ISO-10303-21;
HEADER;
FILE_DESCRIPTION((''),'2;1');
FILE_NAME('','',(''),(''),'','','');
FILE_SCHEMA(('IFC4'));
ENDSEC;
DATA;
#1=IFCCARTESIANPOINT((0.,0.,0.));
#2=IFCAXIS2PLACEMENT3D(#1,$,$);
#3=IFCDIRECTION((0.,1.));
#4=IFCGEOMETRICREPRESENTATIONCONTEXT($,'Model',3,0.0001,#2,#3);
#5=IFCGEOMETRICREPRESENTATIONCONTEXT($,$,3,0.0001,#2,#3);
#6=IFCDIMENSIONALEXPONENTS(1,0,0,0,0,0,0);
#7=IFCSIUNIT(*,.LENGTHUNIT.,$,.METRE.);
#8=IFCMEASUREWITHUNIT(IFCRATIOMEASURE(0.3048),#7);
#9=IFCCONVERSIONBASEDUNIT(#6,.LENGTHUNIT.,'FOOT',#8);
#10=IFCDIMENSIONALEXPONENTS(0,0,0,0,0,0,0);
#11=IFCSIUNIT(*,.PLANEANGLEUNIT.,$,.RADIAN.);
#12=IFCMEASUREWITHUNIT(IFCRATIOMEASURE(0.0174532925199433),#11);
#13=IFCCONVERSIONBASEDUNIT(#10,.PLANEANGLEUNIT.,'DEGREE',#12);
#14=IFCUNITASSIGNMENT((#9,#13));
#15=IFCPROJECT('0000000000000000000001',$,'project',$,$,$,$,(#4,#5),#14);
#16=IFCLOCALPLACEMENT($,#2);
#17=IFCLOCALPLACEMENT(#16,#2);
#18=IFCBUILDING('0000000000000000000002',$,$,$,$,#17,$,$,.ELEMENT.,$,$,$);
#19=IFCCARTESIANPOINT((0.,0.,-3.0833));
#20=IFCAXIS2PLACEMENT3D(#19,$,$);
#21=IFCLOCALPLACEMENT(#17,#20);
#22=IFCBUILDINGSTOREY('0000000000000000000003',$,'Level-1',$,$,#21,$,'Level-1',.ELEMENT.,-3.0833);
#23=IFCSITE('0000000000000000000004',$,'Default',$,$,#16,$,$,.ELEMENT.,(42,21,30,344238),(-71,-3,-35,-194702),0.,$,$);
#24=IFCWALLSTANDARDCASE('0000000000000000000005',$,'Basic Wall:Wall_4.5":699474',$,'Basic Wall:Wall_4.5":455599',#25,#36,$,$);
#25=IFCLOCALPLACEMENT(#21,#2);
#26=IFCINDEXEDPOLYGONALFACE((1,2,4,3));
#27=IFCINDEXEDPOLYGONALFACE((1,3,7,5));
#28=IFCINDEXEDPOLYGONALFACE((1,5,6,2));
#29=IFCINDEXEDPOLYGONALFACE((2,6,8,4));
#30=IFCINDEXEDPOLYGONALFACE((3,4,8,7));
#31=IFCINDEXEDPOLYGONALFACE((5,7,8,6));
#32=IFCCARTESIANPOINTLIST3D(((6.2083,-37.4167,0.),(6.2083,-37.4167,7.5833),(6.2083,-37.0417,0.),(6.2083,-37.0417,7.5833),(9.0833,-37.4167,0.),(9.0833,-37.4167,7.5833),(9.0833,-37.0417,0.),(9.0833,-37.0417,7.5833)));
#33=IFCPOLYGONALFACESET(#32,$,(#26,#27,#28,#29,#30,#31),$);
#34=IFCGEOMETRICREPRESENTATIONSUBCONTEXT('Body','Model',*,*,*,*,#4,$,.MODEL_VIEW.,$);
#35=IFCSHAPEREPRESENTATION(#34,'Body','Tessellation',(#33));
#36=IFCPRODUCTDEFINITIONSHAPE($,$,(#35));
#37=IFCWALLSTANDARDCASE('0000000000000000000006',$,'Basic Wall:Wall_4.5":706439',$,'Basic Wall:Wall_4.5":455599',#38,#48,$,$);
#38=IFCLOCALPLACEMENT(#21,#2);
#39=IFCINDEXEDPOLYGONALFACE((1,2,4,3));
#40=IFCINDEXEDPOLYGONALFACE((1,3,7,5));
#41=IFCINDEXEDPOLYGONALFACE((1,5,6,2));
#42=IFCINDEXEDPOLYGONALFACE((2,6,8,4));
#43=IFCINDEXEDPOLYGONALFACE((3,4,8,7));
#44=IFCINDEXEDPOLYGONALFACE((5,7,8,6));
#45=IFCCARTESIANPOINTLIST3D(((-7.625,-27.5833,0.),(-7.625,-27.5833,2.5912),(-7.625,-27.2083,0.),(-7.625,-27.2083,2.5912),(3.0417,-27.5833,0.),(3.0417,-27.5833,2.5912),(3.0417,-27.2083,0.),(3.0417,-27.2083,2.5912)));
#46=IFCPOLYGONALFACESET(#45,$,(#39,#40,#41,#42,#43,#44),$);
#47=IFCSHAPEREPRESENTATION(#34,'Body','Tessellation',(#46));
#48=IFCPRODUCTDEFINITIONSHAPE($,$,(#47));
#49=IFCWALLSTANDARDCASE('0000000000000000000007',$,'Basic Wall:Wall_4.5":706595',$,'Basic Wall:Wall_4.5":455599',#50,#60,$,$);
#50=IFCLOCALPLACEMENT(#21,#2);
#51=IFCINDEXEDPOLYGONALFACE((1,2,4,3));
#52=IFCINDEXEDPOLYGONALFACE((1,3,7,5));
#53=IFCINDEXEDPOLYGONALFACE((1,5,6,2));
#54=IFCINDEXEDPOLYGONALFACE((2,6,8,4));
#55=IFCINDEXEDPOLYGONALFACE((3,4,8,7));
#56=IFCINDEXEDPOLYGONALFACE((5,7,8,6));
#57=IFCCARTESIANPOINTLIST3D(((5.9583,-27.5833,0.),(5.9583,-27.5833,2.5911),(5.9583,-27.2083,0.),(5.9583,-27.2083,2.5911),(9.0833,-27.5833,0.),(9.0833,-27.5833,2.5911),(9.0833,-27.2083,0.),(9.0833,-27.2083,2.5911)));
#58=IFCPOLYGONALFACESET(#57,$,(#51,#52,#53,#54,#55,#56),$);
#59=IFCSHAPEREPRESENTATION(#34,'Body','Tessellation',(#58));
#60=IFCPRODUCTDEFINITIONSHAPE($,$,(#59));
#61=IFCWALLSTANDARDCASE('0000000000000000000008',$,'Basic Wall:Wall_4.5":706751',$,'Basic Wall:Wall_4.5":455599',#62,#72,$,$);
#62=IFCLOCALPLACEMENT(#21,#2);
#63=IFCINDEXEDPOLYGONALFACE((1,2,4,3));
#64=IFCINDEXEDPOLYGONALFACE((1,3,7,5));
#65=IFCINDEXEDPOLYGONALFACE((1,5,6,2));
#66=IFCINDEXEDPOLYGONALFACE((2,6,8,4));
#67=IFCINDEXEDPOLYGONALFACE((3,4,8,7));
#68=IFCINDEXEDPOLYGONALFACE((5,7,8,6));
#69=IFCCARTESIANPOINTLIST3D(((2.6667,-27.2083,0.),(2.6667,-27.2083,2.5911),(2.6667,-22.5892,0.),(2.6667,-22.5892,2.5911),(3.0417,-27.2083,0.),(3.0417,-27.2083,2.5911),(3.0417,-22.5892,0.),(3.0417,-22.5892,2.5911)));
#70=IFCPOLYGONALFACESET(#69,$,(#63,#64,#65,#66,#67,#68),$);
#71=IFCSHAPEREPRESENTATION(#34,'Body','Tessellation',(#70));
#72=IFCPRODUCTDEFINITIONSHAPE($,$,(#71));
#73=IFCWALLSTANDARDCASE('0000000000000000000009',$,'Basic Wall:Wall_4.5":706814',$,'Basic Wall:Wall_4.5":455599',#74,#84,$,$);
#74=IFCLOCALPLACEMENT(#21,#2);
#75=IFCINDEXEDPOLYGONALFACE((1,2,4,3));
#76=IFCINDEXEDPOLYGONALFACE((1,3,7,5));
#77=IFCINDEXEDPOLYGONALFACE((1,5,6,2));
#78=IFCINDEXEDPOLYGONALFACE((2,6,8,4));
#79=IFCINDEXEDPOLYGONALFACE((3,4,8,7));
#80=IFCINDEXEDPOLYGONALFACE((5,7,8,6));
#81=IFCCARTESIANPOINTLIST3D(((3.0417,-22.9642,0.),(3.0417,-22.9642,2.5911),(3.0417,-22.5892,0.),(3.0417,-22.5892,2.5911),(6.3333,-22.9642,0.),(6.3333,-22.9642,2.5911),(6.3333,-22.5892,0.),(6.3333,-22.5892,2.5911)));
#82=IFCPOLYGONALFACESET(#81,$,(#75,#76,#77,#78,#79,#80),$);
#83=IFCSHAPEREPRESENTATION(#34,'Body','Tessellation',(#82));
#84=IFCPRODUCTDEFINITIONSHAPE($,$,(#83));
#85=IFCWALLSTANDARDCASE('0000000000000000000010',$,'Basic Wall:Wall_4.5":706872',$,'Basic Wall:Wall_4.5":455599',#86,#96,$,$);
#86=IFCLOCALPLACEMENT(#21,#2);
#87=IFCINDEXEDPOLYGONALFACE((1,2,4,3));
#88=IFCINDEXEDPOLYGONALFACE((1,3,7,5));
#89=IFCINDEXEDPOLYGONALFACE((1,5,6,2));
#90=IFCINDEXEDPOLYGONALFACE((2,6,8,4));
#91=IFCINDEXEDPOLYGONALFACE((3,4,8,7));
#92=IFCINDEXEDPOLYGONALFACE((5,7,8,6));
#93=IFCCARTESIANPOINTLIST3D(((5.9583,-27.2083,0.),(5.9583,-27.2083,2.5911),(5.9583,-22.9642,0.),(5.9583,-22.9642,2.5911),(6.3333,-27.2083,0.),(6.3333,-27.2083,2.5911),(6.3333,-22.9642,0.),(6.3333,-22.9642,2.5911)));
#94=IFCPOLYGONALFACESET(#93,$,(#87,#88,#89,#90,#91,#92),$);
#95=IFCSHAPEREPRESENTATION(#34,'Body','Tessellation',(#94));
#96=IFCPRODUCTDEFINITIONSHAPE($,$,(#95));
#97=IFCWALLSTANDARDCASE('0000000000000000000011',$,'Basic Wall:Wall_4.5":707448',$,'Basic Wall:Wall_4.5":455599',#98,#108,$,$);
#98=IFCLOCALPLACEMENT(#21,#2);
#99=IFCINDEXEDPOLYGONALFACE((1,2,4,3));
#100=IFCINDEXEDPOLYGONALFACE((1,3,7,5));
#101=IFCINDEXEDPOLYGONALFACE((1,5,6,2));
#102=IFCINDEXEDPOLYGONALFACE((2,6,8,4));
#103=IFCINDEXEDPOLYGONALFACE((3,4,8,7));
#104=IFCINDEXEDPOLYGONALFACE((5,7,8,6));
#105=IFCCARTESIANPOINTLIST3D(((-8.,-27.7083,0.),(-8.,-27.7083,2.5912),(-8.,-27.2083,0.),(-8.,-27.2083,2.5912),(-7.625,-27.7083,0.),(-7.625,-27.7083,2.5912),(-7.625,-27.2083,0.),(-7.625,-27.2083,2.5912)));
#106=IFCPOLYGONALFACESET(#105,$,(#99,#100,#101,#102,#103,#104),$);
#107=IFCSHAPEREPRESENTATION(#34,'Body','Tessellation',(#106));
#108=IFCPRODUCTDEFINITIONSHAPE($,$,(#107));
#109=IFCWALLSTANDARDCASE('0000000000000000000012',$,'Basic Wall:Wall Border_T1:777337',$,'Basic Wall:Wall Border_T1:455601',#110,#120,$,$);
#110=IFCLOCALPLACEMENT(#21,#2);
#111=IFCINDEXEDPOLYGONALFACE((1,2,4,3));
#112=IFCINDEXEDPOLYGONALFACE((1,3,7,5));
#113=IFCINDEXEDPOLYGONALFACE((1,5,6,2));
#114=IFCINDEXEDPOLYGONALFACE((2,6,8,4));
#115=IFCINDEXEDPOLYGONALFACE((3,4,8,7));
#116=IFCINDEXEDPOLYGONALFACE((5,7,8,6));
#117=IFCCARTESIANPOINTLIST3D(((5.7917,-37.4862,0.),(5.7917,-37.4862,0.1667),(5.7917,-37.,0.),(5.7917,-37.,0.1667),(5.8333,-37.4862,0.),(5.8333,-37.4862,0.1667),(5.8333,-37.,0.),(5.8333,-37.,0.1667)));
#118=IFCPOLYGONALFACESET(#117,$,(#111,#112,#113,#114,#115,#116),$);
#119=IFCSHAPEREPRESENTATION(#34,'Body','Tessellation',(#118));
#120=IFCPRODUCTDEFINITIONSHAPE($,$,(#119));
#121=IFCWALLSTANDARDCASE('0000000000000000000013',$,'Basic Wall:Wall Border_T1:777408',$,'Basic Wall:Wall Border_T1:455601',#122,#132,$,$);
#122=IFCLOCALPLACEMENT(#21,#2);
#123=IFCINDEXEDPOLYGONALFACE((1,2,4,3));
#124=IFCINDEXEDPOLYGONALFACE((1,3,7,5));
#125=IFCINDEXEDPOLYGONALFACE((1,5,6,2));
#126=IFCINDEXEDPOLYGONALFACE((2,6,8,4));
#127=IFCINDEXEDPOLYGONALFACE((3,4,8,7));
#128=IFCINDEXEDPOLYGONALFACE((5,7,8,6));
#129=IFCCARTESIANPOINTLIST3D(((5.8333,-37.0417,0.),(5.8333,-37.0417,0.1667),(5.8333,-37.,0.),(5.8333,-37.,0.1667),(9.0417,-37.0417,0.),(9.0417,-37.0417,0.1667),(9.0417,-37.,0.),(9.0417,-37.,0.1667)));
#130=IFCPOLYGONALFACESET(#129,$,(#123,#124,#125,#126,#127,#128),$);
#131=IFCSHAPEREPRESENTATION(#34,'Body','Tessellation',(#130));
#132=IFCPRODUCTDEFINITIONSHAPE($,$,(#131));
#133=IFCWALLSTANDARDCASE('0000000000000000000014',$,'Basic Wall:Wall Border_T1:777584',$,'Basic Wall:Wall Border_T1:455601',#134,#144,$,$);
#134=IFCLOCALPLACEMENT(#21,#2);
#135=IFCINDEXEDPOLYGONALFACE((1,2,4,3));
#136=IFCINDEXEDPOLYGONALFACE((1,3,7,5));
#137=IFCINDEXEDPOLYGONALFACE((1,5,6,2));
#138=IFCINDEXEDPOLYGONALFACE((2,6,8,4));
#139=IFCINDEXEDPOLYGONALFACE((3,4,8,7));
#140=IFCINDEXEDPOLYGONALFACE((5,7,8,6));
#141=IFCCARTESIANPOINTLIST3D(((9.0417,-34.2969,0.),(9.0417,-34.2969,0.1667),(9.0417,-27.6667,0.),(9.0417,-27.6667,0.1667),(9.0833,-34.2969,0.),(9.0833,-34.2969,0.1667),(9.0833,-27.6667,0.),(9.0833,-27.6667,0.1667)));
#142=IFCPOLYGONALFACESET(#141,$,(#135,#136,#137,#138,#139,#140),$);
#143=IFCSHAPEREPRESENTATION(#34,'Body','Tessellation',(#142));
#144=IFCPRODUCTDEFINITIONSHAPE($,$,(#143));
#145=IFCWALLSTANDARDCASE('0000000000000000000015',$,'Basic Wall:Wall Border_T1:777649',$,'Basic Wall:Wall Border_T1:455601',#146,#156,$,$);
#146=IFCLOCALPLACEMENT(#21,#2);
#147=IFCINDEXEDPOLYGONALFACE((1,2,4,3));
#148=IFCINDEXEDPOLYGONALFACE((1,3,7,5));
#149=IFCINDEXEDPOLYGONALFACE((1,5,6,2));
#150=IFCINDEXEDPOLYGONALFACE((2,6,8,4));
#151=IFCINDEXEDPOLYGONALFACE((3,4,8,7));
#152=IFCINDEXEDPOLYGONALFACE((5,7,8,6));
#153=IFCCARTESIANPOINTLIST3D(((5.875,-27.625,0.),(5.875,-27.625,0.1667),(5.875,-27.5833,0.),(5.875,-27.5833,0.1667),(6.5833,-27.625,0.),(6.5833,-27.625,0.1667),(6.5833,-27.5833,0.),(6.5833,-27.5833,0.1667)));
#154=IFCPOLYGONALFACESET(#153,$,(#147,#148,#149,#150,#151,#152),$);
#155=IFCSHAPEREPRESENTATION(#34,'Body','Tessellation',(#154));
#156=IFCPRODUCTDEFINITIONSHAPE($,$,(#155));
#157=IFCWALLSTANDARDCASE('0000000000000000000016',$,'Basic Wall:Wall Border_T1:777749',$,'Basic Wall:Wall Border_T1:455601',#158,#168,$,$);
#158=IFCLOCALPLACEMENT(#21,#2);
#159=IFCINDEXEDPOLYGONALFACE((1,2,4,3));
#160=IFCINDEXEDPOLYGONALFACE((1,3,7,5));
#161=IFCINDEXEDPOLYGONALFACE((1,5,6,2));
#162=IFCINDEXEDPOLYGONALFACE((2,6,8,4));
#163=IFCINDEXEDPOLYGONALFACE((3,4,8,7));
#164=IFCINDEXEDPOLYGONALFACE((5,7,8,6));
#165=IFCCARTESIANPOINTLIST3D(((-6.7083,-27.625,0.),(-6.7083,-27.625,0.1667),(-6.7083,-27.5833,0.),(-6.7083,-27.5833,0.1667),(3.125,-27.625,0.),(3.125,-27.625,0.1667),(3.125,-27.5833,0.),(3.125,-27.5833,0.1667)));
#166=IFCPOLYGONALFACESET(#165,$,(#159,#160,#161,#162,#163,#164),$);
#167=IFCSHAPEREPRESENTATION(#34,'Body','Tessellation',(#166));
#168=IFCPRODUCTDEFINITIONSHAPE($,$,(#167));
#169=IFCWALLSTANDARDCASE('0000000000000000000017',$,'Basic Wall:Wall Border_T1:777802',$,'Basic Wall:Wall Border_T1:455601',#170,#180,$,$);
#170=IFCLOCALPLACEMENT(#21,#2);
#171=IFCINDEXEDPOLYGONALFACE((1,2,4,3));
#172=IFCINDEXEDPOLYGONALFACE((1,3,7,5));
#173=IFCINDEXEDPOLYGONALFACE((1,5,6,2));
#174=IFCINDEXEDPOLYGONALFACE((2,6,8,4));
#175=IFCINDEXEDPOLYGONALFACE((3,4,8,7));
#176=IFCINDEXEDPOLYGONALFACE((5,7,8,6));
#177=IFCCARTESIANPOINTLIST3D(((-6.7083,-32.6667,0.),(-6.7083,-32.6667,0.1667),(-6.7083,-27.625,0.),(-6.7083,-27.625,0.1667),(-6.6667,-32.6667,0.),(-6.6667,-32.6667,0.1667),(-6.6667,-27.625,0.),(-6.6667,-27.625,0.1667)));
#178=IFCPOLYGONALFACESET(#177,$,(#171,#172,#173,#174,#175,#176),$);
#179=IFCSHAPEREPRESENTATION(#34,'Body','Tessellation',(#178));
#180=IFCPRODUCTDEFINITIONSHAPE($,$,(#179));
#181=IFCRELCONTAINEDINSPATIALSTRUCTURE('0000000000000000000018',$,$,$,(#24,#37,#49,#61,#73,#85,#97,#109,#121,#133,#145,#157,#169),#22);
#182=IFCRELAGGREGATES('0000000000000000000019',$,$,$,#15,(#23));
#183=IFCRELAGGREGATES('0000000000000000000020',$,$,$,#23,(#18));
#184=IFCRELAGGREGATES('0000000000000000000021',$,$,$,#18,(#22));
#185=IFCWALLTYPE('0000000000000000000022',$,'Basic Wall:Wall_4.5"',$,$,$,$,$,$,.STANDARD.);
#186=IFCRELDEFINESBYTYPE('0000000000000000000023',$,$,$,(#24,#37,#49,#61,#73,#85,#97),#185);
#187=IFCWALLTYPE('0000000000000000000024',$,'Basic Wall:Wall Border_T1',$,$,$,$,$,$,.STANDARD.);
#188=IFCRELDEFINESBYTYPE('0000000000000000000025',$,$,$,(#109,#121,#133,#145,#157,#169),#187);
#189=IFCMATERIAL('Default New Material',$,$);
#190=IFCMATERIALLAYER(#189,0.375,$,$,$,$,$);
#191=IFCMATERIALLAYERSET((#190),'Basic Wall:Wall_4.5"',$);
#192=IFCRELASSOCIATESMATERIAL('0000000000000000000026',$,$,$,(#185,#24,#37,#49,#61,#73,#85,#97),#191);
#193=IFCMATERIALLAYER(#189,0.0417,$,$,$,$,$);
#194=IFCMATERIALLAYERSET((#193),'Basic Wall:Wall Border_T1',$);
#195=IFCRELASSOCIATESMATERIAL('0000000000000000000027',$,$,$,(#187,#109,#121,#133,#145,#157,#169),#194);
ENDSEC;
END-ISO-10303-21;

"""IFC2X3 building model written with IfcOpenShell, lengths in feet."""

from ifc_helpers import new_model, entity, si_unit, converted_unit, direction, frame, frame_2d, origin, place, context, subcontext, project, spatial, rectangle, extrude, material, layer, layer_set, layer_usage, type_object, element, save


model = new_model("IFC2X3")

# Units and contexts
model_context = context("Model", 3, precision=0.0001, world=origin(), true_north=direction((0.0, 1.0)))
context_of_model = context(None, 3, precision=0.0001, world=origin(), true_north=direction((0.0, 1.0)))
body_context = subcontext(model_context, "Body", "Model", "MODEL_VIEW")
ifc_project = project(units=[converted_unit("LENGTHUNIT", "FOOT", entity("IfcRatioMeasure", 0.3048), si_unit("LENGTHUNIT", "METRE"), dimensions=[1, 0, 0, 0, 0, 0, 0]), converted_unit("PLANEANGLEUNIT", "DEGREE", entity("IfcRatioMeasure", 0.0174532925199433), si_unit("PLANEANGLEUNIT", "RADIAN"), dimensions=[0, 0, 0, 0, 0, 0, 0])], contexts=[model_context, context_of_model])

# Site, building, storey
site_placement = place(None, origin())
site = spatial("IfcSite", under=ifc_project, at=site_placement, Name="Default", CompositionType="ELEMENT", RefLatitude=(42, 21, 30, 344238), RefLongitude=(-71, -3, -35, -194702), RefElevation=0.0)
building_placement = place(site_placement, origin())
building = spatial("IfcBuilding", under=site, at=building_placement, CompositionType="ELEMENT")
storey_placement = place(building_placement, frame((0.0, 0.0, -3.0833)))
storey = spatial("IfcBuildingStorey", under=building, at=storey_placement, Name="Level-1", LongName="Level-1", CompositionType="ELEMENT", Elevation=-3.0833)

# Shared definitions
ifc_material_1 = material(Name="Default New Material")

# Walls
ifc_layer_1 = layer(ifc_material_1, 0.375)
ifc_layer_set_1 = layer_set([ifc_layer_1], Name="Basic Wall:Wall_4.5\"")
ifc_layer_usage_1 = layer_usage(ifc_layer_set_1, "AXIS2", "NEGATIVE", 0.1875)
wall_type_1 = type_object("IfcWallType", Name="Basic Wall:Wall_4.5\"", PredefinedType="STANDARD", material=ifc_layer_set_1)
wall_1_placement = place(storey_placement, frame((6.2083, -37.2292, 0.0)))
element("IfcWallStandardCase", 1, at=wall_1_placement, inside=storey, type_object=wall_type_1, material=ifc_layer_usage_1, Name="Basic Wall:Wall_4.5\":699474", ObjectType="Basic Wall:Wall_4.5\":455599", context=body_context, shape_type="SweptSolid", body=[
    extrude(rectangle(XDim=2.875, YDim=0.375, at=frame_2d((1.4375, 0.0), x_axis=(-1.0, 0.0))), origin(), (0.0, 0.0, 1.0), 7.5833),
])
ifc_layer_usage_2 = layer_usage(ifc_layer_set_1, "AXIS2", "POSITIVE", -0.1875)
wall_2_placement = place(storey_placement, frame((3.0417, -27.3958, 0.0), z_axis=(0.0, 0.0, 1.0), x_axis=(-1.0, 0.0, 0.0)))
element("IfcWallStandardCase", 2, at=wall_2_placement, inside=storey, type_object=wall_type_1, material=ifc_layer_usage_2, Name="Basic Wall:Wall_4.5\":706439", ObjectType="Basic Wall:Wall_4.5\":455599", context=body_context, shape_type="SweptSolid", body=[
    extrude(rectangle(XDim=10.6667, YDim=0.375, at=frame_2d((5.3333, 0.0), x_axis=(-1.0, 0.0))), origin(), (0.0, 0.0, 1.0), 2.5912),
])
ifc_layer_usage_3 = layer_usage(ifc_layer_set_1, "AXIS2", "NEGATIVE", 0.1875)
wall_3_placement = place(storey_placement, frame((9.0833, -27.3958, 0.0), z_axis=(0.0, 0.0, 1.0), x_axis=(-1.0, 0.0, 0.0)))
element("IfcWallStandardCase", 3, at=wall_3_placement, inside=storey, type_object=wall_type_1, material=ifc_layer_usage_3, Name="Basic Wall:Wall_4.5\":706595", ObjectType="Basic Wall:Wall_4.5\":455599", context=body_context, shape_type="SweptSolid", body=[
    extrude(rectangle(XDim=3.125, YDim=0.375, at=frame_2d((1.5625, 0.0), x_axis=(-1.0, 0.0))), origin(), (0.0, 0.0, 1.0), 2.5911),
])
ifc_layer_usage_4 = layer_usage(ifc_layer_set_1, "AXIS2", "NEGATIVE", 0.1875)
wall_4_placement = place(storey_placement, frame((2.8542, -27.2083, 0.0), z_axis=(0.0, 0.0, 1.0), x_axis=(0.0, 1.0, 0.0)))
element("IfcWallStandardCase", 4, at=wall_4_placement, inside=storey, type_object=wall_type_1, material=ifc_layer_usage_4, Name="Basic Wall:Wall_4.5\":706751", ObjectType="Basic Wall:Wall_4.5\":455599", context=body_context, shape_type="SweptSolid", body=[
    extrude(rectangle(XDim=4.6192, YDim=0.375, at=frame_2d((2.3096, 0.0), x_axis=(-1.0, 0.0))), origin(), (0.0, 0.0, 1.0), 2.5911),
])
ifc_layer_usage_5 = layer_usage(ifc_layer_set_1, "AXIS2", "NEGATIVE", 0.1875)
wall_5_placement = place(storey_placement, frame((3.0417, -22.7767, 0.0)))
element("IfcWallStandardCase", 5, at=wall_5_placement, inside=storey, type_object=wall_type_1, material=ifc_layer_usage_5, Name="Basic Wall:Wall_4.5\":706814", ObjectType="Basic Wall:Wall_4.5\":455599", context=body_context, shape_type="SweptSolid", body=[
    extrude(rectangle(XDim=3.2917, YDim=0.375, at=frame_2d((1.6458, 0.0), x_axis=(-1.0, 0.0))), origin(), (0.0, 0.0, 1.0), 2.5911),
])
ifc_layer_usage_6 = layer_usage(ifc_layer_set_1, "AXIS2", "NEGATIVE", 0.1875)
wall_6_placement = place(storey_placement, frame((6.1458, -22.9642, 0.0), z_axis=(0.0, 0.0, 1.0), x_axis=(0.0, -1.0, 0.0)))
element("IfcWallStandardCase", 6, at=wall_6_placement, inside=storey, type_object=wall_type_1, material=ifc_layer_usage_6, Name="Basic Wall:Wall_4.5\":706872", ObjectType="Basic Wall:Wall_4.5\":455599", context=body_context, shape_type="SweptSolid", body=[
    extrude(rectangle(XDim=4.2442, YDim=0.375, at=frame_2d((2.1221, 0.0), x_axis=(-1.0, 0.0))), origin(), (0.0, 0.0, 1.0), 2.5911),
])
ifc_layer_usage_7 = layer_usage(ifc_layer_set_1, "AXIS2", "POSITIVE", -0.1875)
wall_7_placement = place(storey_placement, frame((-7.8125, -27.2083, 0.0), z_axis=(0.0, 0.0, 1.0), x_axis=(0.0, -1.0, 0.0)))
element("IfcWallStandardCase", 7, at=wall_7_placement, inside=storey, type_object=wall_type_1, material=ifc_layer_usage_7, Name="Basic Wall:Wall_4.5\":707448", ObjectType="Basic Wall:Wall_4.5\":455599", context=body_context, shape_type="SweptSolid", body=[
    extrude(rectangle(XDim=0.5, YDim=0.375, at=frame_2d((0.25, 0.0), x_axis=(-1.0, 0.0))), origin(), (0.0, 0.0, 1.0), 2.5912),
])
ifc_layer_2 = layer(ifc_material_1, 0.0417)
ifc_layer_set_2 = layer_set([ifc_layer_2], Name="Basic Wall:Wall Border_T1")
ifc_layer_usage_8 = layer_usage(ifc_layer_set_2, "AXIS2", "NEGATIVE", 0.0208)
wall_type_2 = type_object("IfcWallType", Name="Basic Wall:Wall Border_T1", PredefinedType="STANDARD", material=ifc_layer_set_2)
wall_8_placement = place(storey_placement, frame((5.8125, -37.4862, 0.0), z_axis=(0.0, 0.0, 1.0), x_axis=(0.0, 1.0, 0.0)))
element("IfcWallStandardCase", 8, at=wall_8_placement, inside=storey, type_object=wall_type_2, material=ifc_layer_usage_8, Name="Basic Wall:Wall Border_T1:777337", ObjectType="Basic Wall:Wall Border_T1:455601", context=body_context, shape_type="SweptSolid", body=[
    extrude(rectangle(XDim=0.4862, YDim=0.0417, at=frame_2d((0.2431, 0.0), x_axis=(-1.0, 0.0))), origin(), (0.0, 0.0, 1.0), 0.1667),
])
ifc_layer_usage_9 = layer_usage(ifc_layer_set_2, "AXIS2", "NEGATIVE", 0.0208)
wall_9_placement = place(storey_placement, frame((5.8333, -37.0208, 0.0)))
element("IfcWallStandardCase", 9, at=wall_9_placement, inside=storey, type_object=wall_type_2, material=ifc_layer_usage_9, Name="Basic Wall:Wall Border_T1:777408", ObjectType="Basic Wall:Wall Border_T1:455601", context=body_context, shape_type="SweptSolid", body=[
    extrude(rectangle(XDim=3.2083, YDim=0.0417, at=frame_2d((1.6042, 0.0), x_axis=(-1.0, 0.0))), origin(), (0.0, 0.0, 1.0), 0.1667),
])
ifc_layer_usage_10 = layer_usage(ifc_layer_set_2, "AXIS2", "NEGATIVE", 0.0208)
wall_10_placement = place(storey_placement, frame((9.0625, -34.2969, 0.0), z_axis=(0.0, 0.0, 1.0), x_axis=(0.0, 1.0, 0.0)))
element("IfcWallStandardCase", 10, at=wall_10_placement, inside=storey, type_object=wall_type_2, material=ifc_layer_usage_10, Name="Basic Wall:Wall Border_T1:777584", ObjectType="Basic Wall:Wall Border_T1:455601", context=body_context, shape_type="SweptSolid", body=[
    extrude(rectangle(XDim=6.6302, YDim=0.0417, at=frame_2d((3.3151, 0.0), x_axis=(-1.0, 0.0))), origin(), (0.0, 0.0, 1.0), 0.1667),
])
ifc_layer_usage_11 = layer_usage(ifc_layer_set_2, "AXIS2", "NEGATIVE", 0.0208)
wall_11_placement = place(storey_placement, frame((6.5833, -27.6042, 0.0), z_axis=(0.0, 0.0, 1.0), x_axis=(-1.0, 0.0, 0.0)))
element("IfcWallStandardCase", 11, at=wall_11_placement, inside=storey, type_object=wall_type_2, material=ifc_layer_usage_11, Name="Basic Wall:Wall Border_T1:777649", ObjectType="Basic Wall:Wall Border_T1:455601", context=body_context, shape_type="SweptSolid", body=[
    extrude(rectangle(XDim=0.7083, YDim=0.0417, at=frame_2d((0.3542, 0.0), x_axis=(-1.0, 0.0))), origin(), (0.0, 0.0, 1.0), 0.1667),
])
ifc_layer_usage_12 = layer_usage(ifc_layer_set_2, "AXIS2", "NEGATIVE", 0.0208)
wall_12_placement = place(storey_placement, frame((3.125, -27.6042, 0.0), z_axis=(0.0, 0.0, 1.0), x_axis=(-1.0, 0.0, 0.0)))
element("IfcWallStandardCase", 12, at=wall_12_placement, inside=storey, type_object=wall_type_2, material=ifc_layer_usage_12, Name="Basic Wall:Wall Border_T1:777749", ObjectType="Basic Wall:Wall Border_T1:455601", context=body_context, shape_type="SweptSolid", body=[
    extrude(rectangle(XDim=9.8333, YDim=0.0417, at=frame_2d((4.9167, 0.0), x_axis=(-1.0, 0.0))), origin(), (0.0, 0.0, 1.0), 0.1667),
])
ifc_layer_usage_13 = layer_usage(ifc_layer_set_2, "AXIS2", "NEGATIVE", 0.0208)
wall_13_placement = place(storey_placement, frame((-6.6875, -27.625, 0.0), z_axis=(0.0, 0.0, 1.0), x_axis=(0.0, -1.0, 0.0)))
element("IfcWallStandardCase", 13, at=wall_13_placement, inside=storey, type_object=wall_type_2, material=ifc_layer_usage_13, Name="Basic Wall:Wall Border_T1:777802", ObjectType="Basic Wall:Wall Border_T1:455601", context=body_context, shape_type="SweptSolid", body=[
    extrude(rectangle(XDim=5.0417, YDim=0.0417, at=frame_2d((2.5208, 0.0), x_axis=(-1.0, 0.0))), origin(), (0.0, 0.0, 1.0), 0.1667),
])

save(model, "model.ifc")
